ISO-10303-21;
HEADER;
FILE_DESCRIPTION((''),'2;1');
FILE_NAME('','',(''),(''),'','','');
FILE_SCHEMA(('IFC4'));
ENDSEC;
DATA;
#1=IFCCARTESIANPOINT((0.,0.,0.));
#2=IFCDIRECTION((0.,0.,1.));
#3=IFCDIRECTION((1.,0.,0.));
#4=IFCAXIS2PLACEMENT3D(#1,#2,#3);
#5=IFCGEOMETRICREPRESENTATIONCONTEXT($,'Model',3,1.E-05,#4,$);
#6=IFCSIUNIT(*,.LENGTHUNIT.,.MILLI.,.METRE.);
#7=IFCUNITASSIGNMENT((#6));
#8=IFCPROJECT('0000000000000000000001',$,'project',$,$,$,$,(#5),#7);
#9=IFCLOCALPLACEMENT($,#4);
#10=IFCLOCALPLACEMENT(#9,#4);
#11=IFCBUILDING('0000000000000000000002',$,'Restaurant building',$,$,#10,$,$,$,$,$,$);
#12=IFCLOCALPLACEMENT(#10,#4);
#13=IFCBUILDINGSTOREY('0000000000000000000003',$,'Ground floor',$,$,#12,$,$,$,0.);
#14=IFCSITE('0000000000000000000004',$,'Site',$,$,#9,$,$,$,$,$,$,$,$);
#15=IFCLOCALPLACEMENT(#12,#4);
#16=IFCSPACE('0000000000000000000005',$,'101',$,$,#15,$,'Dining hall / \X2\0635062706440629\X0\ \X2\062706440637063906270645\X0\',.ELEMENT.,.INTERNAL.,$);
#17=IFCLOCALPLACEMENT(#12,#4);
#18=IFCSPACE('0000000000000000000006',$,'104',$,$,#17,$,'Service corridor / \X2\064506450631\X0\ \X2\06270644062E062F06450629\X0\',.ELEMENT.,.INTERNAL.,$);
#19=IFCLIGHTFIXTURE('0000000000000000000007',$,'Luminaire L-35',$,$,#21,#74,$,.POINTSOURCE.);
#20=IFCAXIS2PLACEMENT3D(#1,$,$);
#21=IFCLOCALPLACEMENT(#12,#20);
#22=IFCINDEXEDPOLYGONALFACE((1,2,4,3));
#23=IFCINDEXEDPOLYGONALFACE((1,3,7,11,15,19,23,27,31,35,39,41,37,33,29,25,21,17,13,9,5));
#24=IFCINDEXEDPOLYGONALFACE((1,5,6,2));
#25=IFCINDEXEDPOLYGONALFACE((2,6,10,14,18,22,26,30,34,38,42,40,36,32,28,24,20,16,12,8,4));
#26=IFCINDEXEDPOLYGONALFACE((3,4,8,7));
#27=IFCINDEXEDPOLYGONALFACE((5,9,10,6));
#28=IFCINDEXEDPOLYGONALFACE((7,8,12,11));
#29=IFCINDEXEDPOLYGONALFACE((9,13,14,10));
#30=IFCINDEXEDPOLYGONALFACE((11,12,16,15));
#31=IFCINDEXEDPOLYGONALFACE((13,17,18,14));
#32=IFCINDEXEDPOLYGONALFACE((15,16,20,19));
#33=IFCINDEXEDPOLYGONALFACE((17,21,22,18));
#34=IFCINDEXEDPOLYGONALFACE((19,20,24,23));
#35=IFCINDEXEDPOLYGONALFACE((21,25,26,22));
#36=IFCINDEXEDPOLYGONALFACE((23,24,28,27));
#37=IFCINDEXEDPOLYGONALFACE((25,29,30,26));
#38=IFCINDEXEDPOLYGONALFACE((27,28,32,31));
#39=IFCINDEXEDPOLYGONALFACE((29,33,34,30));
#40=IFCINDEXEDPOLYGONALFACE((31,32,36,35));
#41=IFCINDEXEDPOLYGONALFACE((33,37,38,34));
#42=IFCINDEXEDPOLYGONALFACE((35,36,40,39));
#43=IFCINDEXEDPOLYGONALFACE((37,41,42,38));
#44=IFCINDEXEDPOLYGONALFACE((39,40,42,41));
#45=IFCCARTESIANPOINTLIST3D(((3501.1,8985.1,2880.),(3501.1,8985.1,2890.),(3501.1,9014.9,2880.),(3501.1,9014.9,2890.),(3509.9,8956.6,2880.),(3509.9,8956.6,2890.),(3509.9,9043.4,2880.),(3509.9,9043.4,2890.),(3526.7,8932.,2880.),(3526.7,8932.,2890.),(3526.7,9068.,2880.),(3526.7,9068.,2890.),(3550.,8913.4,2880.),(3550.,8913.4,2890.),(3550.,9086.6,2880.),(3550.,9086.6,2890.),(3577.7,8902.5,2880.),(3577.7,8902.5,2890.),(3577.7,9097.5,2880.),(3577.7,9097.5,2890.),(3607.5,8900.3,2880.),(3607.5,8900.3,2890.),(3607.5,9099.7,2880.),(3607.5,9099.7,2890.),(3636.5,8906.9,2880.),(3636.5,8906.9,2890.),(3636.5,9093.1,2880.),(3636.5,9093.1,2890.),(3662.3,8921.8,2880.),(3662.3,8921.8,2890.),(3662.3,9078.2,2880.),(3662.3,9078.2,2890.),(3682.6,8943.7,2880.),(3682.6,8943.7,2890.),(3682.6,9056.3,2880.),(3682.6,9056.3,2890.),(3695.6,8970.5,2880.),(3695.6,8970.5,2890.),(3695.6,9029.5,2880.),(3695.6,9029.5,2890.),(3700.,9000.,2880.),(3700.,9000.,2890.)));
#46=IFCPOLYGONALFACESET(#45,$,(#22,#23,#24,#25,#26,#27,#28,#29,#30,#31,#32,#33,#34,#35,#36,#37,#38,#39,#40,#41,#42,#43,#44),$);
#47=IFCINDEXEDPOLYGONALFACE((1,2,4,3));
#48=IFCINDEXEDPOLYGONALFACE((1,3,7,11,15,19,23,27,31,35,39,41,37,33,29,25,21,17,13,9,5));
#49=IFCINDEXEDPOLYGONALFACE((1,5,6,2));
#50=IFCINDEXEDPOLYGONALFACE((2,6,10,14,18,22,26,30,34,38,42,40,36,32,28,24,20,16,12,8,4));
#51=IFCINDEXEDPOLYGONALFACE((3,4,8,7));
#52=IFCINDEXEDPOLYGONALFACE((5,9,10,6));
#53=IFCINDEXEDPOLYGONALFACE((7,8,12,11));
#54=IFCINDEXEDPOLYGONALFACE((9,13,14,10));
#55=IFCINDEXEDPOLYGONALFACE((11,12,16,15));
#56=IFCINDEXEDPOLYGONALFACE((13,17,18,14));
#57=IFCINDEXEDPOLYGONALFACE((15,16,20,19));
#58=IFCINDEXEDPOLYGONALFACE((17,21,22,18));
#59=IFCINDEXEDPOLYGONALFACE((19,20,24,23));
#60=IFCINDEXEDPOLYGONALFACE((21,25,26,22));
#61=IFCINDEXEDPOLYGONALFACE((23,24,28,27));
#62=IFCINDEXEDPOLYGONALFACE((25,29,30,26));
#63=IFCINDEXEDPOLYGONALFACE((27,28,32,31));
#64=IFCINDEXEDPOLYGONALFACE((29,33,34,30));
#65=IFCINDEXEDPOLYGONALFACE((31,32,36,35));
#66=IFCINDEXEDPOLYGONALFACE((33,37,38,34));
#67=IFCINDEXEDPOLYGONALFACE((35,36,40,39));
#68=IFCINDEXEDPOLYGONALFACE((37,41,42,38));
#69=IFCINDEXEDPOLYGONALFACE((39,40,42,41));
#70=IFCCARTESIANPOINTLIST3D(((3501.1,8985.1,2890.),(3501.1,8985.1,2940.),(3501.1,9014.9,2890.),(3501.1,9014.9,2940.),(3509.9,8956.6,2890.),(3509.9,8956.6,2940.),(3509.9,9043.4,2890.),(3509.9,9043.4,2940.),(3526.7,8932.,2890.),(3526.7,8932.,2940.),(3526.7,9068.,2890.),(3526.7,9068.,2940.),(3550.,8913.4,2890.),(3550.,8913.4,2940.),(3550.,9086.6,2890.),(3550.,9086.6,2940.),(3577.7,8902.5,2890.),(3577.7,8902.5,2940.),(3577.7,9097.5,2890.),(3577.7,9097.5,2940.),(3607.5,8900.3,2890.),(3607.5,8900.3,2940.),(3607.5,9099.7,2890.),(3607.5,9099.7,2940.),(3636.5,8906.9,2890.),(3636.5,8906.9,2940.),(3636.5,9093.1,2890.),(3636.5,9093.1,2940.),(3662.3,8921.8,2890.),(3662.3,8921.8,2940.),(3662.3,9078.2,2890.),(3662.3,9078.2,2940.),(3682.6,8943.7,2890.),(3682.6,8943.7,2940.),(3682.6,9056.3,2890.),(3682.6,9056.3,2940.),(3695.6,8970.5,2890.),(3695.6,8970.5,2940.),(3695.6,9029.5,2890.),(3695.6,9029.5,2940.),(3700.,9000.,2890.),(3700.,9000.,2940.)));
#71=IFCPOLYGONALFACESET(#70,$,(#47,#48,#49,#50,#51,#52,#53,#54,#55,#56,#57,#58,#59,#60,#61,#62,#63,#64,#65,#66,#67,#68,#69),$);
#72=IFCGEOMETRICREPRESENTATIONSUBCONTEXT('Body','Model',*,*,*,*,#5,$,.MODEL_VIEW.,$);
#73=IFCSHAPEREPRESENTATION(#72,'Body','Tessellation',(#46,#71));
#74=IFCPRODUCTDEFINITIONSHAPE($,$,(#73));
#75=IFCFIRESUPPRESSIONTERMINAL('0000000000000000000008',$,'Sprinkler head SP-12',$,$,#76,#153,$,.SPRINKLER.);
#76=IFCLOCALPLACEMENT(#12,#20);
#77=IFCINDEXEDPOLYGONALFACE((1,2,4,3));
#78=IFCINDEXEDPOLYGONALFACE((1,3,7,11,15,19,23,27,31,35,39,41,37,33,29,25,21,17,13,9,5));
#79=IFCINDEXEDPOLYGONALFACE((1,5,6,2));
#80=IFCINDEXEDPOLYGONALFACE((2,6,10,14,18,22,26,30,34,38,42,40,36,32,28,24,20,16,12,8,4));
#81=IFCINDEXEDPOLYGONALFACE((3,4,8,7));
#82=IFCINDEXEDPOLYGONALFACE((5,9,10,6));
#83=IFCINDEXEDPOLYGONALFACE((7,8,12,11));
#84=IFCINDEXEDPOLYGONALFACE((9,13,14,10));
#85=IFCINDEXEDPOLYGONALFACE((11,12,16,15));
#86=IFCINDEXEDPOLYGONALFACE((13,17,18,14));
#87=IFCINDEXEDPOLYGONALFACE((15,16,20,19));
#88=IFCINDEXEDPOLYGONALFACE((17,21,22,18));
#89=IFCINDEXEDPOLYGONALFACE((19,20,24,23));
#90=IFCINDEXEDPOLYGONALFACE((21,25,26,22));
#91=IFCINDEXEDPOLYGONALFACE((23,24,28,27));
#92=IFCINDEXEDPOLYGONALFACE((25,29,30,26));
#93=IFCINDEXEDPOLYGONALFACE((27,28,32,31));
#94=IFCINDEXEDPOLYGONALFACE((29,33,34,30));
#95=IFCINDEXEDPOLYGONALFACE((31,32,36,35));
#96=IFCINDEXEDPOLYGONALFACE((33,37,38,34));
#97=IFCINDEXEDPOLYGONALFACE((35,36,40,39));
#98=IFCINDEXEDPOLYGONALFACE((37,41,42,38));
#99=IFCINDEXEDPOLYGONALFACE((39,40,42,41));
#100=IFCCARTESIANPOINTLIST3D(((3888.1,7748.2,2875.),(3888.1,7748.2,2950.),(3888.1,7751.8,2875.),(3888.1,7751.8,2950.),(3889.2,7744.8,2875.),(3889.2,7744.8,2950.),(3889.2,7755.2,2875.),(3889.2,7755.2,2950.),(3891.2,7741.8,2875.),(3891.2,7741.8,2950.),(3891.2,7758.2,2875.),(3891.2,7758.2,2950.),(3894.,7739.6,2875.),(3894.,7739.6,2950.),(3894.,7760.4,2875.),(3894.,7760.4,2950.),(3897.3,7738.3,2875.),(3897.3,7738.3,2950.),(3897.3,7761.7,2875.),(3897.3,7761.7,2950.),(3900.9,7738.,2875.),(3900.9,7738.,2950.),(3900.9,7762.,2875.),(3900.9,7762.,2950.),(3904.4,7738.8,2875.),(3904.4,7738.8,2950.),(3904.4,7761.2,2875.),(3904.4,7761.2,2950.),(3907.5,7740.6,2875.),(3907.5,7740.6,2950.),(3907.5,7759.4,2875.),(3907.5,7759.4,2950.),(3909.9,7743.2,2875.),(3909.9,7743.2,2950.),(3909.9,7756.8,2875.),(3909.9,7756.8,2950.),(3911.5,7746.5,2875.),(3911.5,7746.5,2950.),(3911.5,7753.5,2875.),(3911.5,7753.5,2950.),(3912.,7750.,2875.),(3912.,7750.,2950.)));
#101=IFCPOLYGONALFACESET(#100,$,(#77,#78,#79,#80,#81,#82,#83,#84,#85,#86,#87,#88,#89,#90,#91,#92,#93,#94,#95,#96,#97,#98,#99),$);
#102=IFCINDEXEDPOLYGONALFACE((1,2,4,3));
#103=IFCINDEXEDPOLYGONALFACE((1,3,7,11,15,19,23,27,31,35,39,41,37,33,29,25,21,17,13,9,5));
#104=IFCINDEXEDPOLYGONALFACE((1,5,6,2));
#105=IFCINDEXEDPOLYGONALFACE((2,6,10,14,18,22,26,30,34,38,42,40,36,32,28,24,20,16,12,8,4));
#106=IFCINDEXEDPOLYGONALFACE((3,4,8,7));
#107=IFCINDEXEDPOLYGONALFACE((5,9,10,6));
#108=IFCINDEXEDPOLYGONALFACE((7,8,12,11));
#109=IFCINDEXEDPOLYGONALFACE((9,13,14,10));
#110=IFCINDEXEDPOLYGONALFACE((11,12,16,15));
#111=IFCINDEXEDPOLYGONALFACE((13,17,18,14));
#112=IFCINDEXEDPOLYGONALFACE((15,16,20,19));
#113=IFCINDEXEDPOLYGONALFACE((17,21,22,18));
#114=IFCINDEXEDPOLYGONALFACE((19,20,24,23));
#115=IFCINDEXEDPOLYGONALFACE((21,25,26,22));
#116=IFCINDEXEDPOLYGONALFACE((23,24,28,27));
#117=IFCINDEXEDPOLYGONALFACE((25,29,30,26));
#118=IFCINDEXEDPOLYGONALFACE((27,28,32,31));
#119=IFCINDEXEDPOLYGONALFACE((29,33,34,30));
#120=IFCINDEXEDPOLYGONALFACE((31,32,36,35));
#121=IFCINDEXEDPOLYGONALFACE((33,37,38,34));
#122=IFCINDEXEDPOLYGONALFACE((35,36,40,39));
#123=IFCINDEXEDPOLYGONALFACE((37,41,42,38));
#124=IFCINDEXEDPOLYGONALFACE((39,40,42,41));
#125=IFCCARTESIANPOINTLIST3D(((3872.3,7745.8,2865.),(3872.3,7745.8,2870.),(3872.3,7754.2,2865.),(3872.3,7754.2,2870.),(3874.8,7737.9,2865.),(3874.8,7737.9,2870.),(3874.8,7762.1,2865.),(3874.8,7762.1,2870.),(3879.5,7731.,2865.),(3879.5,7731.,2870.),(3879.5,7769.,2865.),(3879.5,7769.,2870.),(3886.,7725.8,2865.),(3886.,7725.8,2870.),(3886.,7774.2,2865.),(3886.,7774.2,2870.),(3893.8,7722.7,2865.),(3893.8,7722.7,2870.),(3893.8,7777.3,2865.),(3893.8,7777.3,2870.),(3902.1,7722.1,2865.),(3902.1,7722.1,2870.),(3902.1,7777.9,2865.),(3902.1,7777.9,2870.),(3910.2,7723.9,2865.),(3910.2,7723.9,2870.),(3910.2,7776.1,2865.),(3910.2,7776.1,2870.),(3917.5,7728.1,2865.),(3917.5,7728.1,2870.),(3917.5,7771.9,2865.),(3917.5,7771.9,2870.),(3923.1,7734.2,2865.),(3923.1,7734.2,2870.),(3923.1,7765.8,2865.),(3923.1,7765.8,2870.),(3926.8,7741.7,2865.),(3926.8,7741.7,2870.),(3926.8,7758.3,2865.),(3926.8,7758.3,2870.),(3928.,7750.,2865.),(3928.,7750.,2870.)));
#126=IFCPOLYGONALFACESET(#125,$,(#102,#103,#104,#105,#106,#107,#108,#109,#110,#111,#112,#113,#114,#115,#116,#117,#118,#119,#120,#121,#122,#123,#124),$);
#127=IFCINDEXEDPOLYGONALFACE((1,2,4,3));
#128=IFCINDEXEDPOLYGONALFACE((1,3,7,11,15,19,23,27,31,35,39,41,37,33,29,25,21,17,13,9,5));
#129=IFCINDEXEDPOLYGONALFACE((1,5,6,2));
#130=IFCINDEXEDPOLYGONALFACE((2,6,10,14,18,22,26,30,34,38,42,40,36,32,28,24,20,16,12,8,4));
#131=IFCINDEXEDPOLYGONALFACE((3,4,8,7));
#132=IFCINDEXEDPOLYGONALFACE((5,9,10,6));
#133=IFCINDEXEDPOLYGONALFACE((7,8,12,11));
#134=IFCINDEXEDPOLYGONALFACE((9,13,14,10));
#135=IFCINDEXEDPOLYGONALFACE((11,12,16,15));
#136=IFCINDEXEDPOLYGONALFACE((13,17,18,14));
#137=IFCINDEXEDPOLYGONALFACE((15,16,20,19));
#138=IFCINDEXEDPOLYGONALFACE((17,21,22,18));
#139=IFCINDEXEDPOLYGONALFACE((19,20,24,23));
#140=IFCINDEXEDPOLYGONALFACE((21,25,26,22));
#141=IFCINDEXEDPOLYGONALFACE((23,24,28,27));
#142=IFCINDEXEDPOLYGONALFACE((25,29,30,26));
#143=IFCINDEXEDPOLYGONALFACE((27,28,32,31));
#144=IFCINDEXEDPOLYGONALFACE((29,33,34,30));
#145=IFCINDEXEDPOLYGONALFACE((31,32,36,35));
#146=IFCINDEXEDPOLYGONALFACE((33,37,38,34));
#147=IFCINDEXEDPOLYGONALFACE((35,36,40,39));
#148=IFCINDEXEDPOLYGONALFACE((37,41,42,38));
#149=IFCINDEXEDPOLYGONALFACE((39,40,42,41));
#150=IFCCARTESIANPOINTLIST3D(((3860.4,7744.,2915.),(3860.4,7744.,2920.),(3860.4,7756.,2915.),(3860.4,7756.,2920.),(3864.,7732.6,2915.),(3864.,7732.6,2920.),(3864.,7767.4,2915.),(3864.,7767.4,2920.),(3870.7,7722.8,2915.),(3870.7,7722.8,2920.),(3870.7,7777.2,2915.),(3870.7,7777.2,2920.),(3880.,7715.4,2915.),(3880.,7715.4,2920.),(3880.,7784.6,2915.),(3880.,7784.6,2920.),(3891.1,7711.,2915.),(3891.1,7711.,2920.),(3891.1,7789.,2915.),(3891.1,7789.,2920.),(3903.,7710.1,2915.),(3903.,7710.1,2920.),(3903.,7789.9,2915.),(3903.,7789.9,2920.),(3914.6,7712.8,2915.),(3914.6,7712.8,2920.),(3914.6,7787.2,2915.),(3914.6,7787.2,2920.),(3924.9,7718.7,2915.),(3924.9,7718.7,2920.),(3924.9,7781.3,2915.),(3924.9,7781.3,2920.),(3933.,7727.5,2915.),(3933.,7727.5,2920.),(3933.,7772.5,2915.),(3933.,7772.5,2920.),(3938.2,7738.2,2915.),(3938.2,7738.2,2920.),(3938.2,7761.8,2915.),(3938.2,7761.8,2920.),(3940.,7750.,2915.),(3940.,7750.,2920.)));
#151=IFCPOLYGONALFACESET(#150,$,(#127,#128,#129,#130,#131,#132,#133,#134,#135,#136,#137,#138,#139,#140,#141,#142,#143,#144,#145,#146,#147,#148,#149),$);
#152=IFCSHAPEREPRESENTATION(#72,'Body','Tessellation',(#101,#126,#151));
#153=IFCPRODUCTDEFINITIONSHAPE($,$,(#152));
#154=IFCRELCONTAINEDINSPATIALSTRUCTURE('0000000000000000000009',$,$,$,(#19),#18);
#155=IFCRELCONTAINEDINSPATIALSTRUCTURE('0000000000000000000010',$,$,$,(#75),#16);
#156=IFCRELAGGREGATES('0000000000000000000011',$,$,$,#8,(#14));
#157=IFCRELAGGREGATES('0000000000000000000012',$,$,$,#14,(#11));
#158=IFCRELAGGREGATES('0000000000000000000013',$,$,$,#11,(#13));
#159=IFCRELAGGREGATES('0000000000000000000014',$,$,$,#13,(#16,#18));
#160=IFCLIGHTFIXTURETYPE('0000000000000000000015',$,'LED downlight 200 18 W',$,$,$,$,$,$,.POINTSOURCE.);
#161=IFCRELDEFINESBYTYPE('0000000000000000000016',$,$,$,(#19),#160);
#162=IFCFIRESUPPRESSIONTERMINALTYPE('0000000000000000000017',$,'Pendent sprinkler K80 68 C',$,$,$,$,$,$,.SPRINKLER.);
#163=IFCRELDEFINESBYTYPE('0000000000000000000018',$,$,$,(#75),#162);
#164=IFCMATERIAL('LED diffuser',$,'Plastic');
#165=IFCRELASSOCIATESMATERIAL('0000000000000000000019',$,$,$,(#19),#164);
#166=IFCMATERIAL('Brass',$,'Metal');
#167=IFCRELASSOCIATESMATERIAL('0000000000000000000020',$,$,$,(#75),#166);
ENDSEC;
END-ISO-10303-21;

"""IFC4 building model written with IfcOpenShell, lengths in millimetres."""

from ifc_helpers import new_model, si_unit, frame, origin, origin_with_axes, origin_2d, place, context, subcontext, project, spatial, circle, extrude, source, transform, mapped, material, type_object, type_shapes, element, save


model = new_model("IFC4")

# Units and contexts
model_context = context("Model", 3, precision=1e-05, world=origin_with_axes())
body_context = subcontext(model_context, "Body", "Model", "MODEL_VIEW")
ifc_project = project(units=[si_unit("LENGTHUNIT", "METRE", prefix="MILLI")], contexts=[model_context])

# Site, building, storey
site_placement = place(None, origin_with_axes())
site = spatial("IfcSite", under=ifc_project, at=site_placement, Name="Site")
building_placement = place(site_placement, origin_with_axes())
building = spatial("IfcBuilding", under=site, at=building_placement, Name="Restaurant building")
storey_placement = place(building_placement, origin_with_axes())
storey = spatial("IfcBuildingStorey", under=building, at=storey_placement, Name="Ground floor", Elevation=0.0)

# Shared definitions
space_1_placement = place(storey_placement, origin_with_axes())
space_1 = spatial("IfcSpace", under=storey, at=space_1_placement, Name="101", LongName="Dining hall / صالة الطعام", CompositionType="ELEMENT", PredefinedType="INTERNAL")

# Shared definitions
ifc_material_1 = material(Name="LED diffuser", Category="Plastic")

# Shared definitions
space_2_placement = place(storey_placement, origin_with_axes())
space_2 = spatial("IfcSpace", under=storey, at=space_2_placement, Name="104", LongName="Service corridor / ممر الخدمة", CompositionType="ELEMENT", PredefinedType="INTERNAL")

# Light fixture
light_fixture_type_1 = type_object("IfcLightFixtureType", Name="LED downlight 200 18 W", PredefinedType="POINTSOURCE")
shared_shape_1 = source(origin(), body_context, "Body", "SweptSolid", [
    extrude(circle(Radius=100.0, at=origin_2d()), frame((0.0, 0.0, -60.0)), (0.0, 0.0, 1.0), 10.0),
    extrude(circle(Radius=100.0, at=origin_2d()), frame((0.0, 0.0, -50.0)), (0.0, 0.0, 1.0), 50.0),
])
type_shapes(light_fixture_type_1, [shared_shape_1])
light_fixture_1_placement = place(storey_placement, frame((3600.0, 9000.0, 2940.0)))
element("IfcLightFixture", 1, at=light_fixture_1_placement, inside=space_2, type_object=light_fixture_type_1, material=ifc_material_1, Name="Luminaire L-35", PredefinedType="POINTSOURCE", context=body_context, shape_type="MappedRepresentation", body=[
    mapped(shared_shape_1, transform((0.0, 0.0, 0.0))),
])

# Fire suppression terminal
ifc_material_2 = material(Name="Brass", Category="Metal")
fire_suppression_terminal_type = type_object("IfcFireSuppressionTerminalType", Name="Pendent sprinkler K80 68 C", PredefinedType="SPRINKLER")
shared_shape_2 = source(origin(), body_context, "Body", "SweptSolid", [
    extrude(circle(Radius=12.0, at=origin_2d()), frame((0.0, 0.0, -75.0)), (0.0, 0.0, 1.0), 75.0),
    extrude(circle(Radius=28.0, at=origin_2d()), frame((0.0, 0.0, -85.0)), (0.0, 0.0, 1.0), 5.0),
    extrude(circle(Radius=40.0, at=origin_2d()), frame((0.0, 0.0, -35.0)), (0.0, 0.0, 1.0), 5.0),
])
type_shapes(fire_suppression_terminal_type, [shared_shape_2])
for number, where, name in (
    (2, (3900.0, 7750.0, 2950.0), "Sprinkler head SP-12"),
):
    element("IfcFireSuppressionTerminal", number, at=place(storey_placement, frame(where)), inside=space_1, type_object=fire_suppression_terminal_type, material=ifc_material_2, Name=name, PredefinedType="SPRINKLER", context=body_context, shape_type="MappedRepresentation", body=[
        mapped(shared_shape_2, transform((0.0, 0.0, 0.0))),
    ])

save(model, "model.ifc")
